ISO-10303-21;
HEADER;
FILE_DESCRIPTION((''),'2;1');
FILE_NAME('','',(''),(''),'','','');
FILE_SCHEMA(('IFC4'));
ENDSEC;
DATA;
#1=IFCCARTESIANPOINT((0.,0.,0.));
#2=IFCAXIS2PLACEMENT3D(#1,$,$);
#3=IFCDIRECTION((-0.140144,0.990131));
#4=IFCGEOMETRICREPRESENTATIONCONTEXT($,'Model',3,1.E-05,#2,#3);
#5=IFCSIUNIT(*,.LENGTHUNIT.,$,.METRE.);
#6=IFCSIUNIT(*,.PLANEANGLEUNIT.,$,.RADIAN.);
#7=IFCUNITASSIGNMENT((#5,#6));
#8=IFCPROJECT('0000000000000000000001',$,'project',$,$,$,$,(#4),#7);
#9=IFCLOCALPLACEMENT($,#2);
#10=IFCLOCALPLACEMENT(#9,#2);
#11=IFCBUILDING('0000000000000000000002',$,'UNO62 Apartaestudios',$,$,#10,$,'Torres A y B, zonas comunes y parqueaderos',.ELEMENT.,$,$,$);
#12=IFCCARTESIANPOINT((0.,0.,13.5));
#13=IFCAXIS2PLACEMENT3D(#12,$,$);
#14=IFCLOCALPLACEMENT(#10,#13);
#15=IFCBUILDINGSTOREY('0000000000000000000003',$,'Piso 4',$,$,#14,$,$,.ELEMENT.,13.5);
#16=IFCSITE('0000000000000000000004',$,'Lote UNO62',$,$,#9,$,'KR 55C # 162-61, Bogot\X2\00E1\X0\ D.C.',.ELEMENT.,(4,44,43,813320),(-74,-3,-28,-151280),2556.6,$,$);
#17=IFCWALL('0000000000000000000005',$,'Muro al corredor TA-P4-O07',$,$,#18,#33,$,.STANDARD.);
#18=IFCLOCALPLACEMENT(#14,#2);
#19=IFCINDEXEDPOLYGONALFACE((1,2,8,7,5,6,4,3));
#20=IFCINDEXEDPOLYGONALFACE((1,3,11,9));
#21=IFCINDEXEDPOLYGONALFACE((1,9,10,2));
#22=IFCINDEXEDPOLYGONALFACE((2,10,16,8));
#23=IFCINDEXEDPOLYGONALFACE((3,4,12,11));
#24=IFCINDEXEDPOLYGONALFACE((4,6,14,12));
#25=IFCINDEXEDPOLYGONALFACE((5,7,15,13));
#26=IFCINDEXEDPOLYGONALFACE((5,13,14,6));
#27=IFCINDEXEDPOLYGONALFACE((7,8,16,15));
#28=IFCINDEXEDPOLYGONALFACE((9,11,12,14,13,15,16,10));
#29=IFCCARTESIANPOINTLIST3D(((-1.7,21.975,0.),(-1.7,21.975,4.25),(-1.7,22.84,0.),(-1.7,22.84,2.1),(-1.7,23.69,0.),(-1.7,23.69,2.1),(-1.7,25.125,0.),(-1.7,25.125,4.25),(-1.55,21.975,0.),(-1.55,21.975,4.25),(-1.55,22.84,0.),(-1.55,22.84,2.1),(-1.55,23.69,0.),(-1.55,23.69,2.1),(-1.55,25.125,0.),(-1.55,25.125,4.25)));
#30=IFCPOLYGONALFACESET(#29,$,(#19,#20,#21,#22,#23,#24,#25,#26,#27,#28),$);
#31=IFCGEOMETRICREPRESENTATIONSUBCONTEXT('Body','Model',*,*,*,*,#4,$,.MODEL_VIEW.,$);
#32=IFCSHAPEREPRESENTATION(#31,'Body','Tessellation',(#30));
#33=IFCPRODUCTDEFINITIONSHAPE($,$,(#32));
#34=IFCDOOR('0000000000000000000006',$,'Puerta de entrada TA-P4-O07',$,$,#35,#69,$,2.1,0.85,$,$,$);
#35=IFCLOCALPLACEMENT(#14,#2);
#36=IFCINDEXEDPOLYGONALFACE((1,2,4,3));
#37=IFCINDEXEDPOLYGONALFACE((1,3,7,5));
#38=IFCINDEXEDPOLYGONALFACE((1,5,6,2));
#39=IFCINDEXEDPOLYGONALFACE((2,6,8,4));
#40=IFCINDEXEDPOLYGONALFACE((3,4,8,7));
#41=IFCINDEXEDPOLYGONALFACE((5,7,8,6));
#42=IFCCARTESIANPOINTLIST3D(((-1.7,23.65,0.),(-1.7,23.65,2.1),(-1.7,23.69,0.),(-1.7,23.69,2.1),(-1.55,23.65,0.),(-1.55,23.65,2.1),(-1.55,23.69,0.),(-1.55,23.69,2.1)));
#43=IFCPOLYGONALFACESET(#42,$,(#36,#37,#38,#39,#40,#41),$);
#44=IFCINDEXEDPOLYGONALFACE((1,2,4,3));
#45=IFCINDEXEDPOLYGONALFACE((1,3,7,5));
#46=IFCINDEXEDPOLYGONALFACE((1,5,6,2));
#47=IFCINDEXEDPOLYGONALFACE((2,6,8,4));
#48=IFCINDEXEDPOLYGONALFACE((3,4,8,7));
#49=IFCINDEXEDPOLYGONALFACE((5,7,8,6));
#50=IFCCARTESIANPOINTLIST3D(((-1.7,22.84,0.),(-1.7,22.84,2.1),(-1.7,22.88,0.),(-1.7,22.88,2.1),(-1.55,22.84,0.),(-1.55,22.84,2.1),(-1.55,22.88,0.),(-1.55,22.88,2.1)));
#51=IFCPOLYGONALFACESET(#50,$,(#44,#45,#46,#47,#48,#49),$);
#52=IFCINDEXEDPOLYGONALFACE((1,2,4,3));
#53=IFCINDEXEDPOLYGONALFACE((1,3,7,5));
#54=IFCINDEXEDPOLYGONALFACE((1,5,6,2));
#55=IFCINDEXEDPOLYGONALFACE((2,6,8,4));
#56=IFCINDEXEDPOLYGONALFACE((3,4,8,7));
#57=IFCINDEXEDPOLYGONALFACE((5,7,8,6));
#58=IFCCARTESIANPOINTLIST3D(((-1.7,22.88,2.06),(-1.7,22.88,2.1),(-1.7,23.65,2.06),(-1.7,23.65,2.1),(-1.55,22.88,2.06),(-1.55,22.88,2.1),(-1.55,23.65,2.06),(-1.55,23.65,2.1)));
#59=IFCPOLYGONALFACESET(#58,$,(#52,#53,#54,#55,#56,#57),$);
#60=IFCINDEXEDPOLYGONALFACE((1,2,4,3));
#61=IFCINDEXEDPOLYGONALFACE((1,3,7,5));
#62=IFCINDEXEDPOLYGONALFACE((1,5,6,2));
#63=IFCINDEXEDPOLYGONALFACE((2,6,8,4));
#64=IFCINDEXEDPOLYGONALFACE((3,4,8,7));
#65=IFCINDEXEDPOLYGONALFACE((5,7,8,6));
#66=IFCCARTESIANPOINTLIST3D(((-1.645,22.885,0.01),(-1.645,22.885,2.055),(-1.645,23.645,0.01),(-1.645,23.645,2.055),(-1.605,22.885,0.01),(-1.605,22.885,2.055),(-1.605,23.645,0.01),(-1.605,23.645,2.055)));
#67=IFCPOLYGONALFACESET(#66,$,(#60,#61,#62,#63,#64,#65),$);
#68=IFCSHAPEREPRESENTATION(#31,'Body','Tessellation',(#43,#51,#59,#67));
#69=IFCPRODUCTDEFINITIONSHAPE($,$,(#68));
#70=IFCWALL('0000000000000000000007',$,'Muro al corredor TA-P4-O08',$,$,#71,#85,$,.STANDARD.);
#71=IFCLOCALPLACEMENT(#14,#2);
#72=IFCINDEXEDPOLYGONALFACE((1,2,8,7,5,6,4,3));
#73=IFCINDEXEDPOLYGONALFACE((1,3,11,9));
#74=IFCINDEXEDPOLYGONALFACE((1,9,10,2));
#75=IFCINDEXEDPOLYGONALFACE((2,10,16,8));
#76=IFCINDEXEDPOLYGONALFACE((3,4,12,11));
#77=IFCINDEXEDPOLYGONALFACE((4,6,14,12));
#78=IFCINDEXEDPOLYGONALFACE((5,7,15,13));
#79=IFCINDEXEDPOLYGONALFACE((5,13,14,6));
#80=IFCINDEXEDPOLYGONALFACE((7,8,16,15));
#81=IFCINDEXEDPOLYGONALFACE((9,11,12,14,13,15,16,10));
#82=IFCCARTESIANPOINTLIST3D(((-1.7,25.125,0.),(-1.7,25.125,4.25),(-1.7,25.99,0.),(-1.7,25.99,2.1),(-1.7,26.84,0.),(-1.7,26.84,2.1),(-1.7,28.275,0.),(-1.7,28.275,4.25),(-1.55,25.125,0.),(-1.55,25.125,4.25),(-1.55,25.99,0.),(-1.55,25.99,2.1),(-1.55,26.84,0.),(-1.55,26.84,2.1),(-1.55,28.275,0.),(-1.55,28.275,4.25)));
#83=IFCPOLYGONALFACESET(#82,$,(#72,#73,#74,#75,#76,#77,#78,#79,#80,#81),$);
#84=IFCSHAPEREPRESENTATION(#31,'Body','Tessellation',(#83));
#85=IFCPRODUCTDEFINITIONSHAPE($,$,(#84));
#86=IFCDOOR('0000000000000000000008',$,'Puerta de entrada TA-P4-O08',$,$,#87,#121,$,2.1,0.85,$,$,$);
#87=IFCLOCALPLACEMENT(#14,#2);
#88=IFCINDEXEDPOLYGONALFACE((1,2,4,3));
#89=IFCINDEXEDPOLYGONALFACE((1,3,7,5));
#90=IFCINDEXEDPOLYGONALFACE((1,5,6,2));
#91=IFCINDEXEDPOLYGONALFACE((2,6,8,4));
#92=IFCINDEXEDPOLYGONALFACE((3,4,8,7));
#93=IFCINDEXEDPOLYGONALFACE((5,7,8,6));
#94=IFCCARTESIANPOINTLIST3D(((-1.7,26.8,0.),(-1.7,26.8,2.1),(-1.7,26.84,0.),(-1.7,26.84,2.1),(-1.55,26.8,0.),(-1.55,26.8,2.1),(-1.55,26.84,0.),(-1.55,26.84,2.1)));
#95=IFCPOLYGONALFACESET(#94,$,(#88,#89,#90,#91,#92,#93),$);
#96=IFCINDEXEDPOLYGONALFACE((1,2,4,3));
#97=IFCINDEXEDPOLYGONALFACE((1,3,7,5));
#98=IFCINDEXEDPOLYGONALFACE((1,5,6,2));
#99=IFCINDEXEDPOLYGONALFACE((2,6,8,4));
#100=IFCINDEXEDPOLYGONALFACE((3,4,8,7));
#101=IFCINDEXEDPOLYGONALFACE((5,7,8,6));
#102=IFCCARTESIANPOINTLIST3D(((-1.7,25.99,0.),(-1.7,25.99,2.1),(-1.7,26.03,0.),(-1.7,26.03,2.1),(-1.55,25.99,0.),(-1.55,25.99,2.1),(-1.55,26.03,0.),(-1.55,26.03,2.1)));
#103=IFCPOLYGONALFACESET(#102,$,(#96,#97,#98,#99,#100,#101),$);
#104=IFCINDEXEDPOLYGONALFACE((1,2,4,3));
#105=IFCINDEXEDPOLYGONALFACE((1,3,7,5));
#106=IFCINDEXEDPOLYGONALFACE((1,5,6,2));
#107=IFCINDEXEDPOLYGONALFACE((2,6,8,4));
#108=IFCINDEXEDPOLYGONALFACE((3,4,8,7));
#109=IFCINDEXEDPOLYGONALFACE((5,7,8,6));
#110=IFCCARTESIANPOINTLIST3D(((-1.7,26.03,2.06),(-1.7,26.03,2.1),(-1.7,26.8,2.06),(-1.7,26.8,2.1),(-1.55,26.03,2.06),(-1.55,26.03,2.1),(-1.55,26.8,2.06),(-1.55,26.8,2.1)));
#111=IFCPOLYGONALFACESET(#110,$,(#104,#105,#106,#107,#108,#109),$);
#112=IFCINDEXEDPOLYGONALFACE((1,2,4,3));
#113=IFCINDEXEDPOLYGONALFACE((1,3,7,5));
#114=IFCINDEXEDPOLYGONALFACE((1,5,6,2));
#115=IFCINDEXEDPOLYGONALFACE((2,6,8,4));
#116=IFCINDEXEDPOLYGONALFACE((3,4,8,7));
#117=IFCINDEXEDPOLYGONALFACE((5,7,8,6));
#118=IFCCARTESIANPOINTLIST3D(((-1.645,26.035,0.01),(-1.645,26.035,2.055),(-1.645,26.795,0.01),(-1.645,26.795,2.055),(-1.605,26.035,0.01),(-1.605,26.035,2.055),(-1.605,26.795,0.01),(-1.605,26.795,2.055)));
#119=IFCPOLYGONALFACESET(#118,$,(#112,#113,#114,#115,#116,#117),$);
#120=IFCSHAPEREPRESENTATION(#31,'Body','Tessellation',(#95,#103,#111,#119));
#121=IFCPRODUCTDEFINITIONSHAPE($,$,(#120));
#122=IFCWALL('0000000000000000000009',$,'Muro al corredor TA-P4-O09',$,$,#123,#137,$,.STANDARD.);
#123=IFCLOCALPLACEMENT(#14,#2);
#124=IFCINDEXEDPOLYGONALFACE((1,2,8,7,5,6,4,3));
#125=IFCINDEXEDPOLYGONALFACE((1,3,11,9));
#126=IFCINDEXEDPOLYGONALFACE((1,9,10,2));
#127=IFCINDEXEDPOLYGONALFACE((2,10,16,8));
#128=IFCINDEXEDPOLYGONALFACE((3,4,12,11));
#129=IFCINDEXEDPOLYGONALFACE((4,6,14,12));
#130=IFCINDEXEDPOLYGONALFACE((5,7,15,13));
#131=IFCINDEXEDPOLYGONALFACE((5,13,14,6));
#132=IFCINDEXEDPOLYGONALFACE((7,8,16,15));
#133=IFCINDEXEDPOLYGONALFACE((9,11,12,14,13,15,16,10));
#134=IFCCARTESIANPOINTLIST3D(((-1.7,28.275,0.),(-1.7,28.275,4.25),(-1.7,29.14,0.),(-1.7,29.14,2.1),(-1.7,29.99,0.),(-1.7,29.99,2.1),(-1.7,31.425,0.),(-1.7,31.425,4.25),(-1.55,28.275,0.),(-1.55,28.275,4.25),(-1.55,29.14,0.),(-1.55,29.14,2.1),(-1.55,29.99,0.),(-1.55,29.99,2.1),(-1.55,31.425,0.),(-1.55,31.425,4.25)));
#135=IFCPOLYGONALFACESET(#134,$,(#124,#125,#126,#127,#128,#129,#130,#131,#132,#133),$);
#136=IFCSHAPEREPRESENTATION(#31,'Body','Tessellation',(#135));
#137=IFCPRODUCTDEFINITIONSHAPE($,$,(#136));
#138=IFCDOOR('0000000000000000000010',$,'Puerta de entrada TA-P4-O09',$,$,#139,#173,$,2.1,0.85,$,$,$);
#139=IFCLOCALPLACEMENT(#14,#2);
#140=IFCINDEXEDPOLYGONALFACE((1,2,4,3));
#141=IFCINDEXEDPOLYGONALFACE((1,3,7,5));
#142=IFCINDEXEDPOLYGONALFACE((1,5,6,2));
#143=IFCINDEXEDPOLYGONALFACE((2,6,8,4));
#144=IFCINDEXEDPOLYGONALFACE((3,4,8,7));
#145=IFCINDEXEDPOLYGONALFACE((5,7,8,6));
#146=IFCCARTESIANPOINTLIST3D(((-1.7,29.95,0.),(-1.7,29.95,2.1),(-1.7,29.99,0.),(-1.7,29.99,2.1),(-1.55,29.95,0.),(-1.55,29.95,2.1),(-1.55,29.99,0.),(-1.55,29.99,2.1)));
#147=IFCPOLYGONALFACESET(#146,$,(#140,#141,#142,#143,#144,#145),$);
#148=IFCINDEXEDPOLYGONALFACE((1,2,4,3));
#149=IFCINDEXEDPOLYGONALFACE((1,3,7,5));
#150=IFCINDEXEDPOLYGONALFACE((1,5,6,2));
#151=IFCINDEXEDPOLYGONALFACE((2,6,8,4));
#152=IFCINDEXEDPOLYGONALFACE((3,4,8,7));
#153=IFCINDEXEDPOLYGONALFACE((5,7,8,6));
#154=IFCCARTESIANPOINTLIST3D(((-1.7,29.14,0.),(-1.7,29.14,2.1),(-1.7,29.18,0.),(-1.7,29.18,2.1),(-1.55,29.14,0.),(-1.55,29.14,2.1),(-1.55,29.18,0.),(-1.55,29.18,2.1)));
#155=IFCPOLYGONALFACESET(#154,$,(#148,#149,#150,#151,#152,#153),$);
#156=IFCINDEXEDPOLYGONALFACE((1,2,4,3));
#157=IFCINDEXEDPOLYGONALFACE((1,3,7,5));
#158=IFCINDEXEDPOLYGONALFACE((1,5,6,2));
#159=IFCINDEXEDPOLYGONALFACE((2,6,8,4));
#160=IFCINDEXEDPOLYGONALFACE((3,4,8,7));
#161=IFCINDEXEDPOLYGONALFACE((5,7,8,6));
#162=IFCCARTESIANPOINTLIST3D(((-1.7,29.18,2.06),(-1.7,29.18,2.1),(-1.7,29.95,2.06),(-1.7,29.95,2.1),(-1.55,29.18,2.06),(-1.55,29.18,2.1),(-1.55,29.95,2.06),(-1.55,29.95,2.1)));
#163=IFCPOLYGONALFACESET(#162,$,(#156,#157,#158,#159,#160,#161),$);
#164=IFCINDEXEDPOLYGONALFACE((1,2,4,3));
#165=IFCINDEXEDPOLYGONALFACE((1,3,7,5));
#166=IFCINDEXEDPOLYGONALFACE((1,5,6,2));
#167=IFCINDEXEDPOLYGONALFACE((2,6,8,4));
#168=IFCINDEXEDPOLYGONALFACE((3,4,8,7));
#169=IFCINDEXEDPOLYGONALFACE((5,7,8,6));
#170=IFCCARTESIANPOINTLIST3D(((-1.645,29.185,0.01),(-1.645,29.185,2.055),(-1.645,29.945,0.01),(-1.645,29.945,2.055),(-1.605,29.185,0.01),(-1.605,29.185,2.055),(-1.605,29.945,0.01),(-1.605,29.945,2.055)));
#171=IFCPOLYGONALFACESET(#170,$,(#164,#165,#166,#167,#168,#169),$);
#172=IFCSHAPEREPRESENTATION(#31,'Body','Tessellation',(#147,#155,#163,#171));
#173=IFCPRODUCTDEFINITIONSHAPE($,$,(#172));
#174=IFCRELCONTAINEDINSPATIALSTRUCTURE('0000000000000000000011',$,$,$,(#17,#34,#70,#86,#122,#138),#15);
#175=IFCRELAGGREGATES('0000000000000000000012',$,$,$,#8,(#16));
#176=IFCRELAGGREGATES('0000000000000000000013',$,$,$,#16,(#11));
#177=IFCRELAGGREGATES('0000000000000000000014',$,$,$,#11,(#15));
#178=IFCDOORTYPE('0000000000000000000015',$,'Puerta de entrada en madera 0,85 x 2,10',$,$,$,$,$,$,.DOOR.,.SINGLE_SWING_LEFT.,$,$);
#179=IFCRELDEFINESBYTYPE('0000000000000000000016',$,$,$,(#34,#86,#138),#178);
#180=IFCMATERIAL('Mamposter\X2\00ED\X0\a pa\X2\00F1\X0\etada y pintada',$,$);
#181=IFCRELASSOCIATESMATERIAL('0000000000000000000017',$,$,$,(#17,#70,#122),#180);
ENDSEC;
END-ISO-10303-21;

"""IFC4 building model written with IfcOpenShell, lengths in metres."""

from ifc_helpers import new_model, si_unit, direction, frame, frame_2d, origin, place, context, subcontext, project, spatial, rectangle, extrude, source, transform, mapped, material, type_object, type_shapes, element, fill, save


model = new_model("IFC4")

# Units and contexts
model_context = context("Model", 3, precision=1e-05, world=origin(), true_north=direction((-0.140144, 0.990131)))
body_context = subcontext(model_context, "Body", "Model", "MODEL_VIEW")
ifc_project = project(units=[si_unit("LENGTHUNIT", "METRE"), si_unit("PLANEANGLEUNIT", "RADIAN")], contexts=[model_context])

# Site, building, storey
site_placement = place(None, origin())
site = spatial("IfcSite", under=ifc_project, at=site_placement, Name="Lote UNO62", LongName="KR 55C # 162-61, Bogotá D.C.", CompositionType="ELEMENT", RefLatitude=(4, 44, 43, 813320), RefLongitude=(-74, -3, -28, -151280), RefElevation=2556.6)
building_placement = place(site_placement, origin())
building = spatial("IfcBuilding", under=site, at=building_placement, Name="UNO62 Apartaestudios", LongName="Torres A y B, zonas comunes y parqueaderos", CompositionType="ELEMENT")
storey_placement = place(building_placement, frame((0.0, 0.0, 13.5)))
storey = spatial("IfcBuildingStorey", under=building, at=storey_placement, Name="Piso 4", CompositionType="ELEMENT", Elevation=13.5)

# Walls, openings, doors
ifc_material = material(Name="Mampostería pañetada y pintada")
door_type = type_object("IfcDoorType", Name="Puerta de entrada en madera 0,85 x 2,10", OperationType="SINGLE_SWING_LEFT", PredefinedType="DOOR")
shared_shape = source(origin(), body_context, "Body", "SweptSolid", [
    extrude(rectangle(XDim=0.15, YDim=0.04, at=frame_2d((-0.075, 1.38))), origin(), (0.0, 0.0, 1.0), 2.1),
    extrude(rectangle(XDim=0.15, YDim=0.04, at=frame_2d((-0.075, 2.19))), origin(), (0.0, 0.0, 1.0), 2.1),
    extrude(rectangle(XDim=0.15, YDim=0.77, at=frame_2d((-0.075, 1.785))), frame((0.0, 0.0, 2.06)), (0.0, 0.0, 1.0), 0.04),
    extrude(rectangle(XDim=0.04, YDim=0.76, at=frame_2d((-0.075, 1.785))), frame((0.0, 0.0, 0.01)), (0.0, 0.0, 1.0), 2.045),
])
type_shapes(door_type, [shared_shape])
wall_1_placement = place(storey_placement, origin())
wall_1 = element("IfcWall", 1, at=wall_1_placement, inside=storey, material=ifc_material, Name="Muro al corredor TA-P4-O07", PredefinedType="STANDARD", context=body_context, shape_type="SweptSolid", body=[
    extrude(rectangle(XDim=0.15, YDim=3.15, at=frame_2d((-1.625, 23.55))), origin(), (0.0, 0.0, 1.0), 4.25),
])
opening_1_placement = place(wall_1_placement, origin())
opening_1 = element("IfcOpeningElement", 2, at=opening_1_placement, cuts=wall_1, PredefinedType="OPENING", context=body_context, shape_type="SweptSolid", body=[
    extrude(rectangle(XDim=0.25, YDim=0.85, at=frame_2d((-1.625, 23.265))), origin(), (0.0, 0.0, 1.0), 2.1),
])
placement_1 = place(storey_placement, frame((-1.7, 25.05, 0.0), z_axis=(0.0, 0.0, 1.0), x_axis=(-1.0, 0.0, 0.0)))
door_1_placement = place(placement_1, origin())
door_1 = element("IfcDoor", 3, at=door_1_placement, inside=storey, type_object=door_type, Name="Puerta de entrada TA-P4-O07", OverallHeight=2.1, OverallWidth=0.85, context=body_context, shape_type="MappedRepresentation", body=[
    mapped(shared_shape, transform((0.0, 0.0, 0.0))),
])
fill(opening_1, door_1)
wall_2_placement = place(storey_placement, origin())
wall_2 = element("IfcWall", 4, at=wall_2_placement, inside=storey, material=ifc_material, Name="Muro al corredor TA-P4-O08", PredefinedType="STANDARD", context=body_context, shape_type="SweptSolid", body=[
    extrude(rectangle(XDim=0.15, YDim=3.15, at=frame_2d((-1.625, 26.7))), origin(), (0.0, 0.0, 1.0), 4.25),
])
opening_2_placement = place(wall_2_placement, origin())
opening_2 = element("IfcOpeningElement", 5, at=opening_2_placement, cuts=wall_2, PredefinedType="OPENING", context=body_context, shape_type="SweptSolid", body=[
    extrude(rectangle(XDim=0.25, YDim=0.85, at=frame_2d((-1.625, 26.415))), origin(), (0.0, 0.0, 1.0), 2.1),
])
placement_2 = place(storey_placement, frame((-1.7, 28.2, 0.0), z_axis=(0.0, 0.0, 1.0), x_axis=(-1.0, 0.0, 0.0)))
door_2_placement = place(placement_2, origin())
door_2 = element("IfcDoor", 6, at=door_2_placement, inside=storey, type_object=door_type, Name="Puerta de entrada TA-P4-O08", OverallHeight=2.1, OverallWidth=0.85, context=body_context, shape_type="MappedRepresentation", body=[
    mapped(shared_shape, transform((0.0, 0.0, 0.0))),
])
fill(opening_2, door_2)
wall_3_placement = place(storey_placement, origin())
wall_3 = element("IfcWall", 7, at=wall_3_placement, inside=storey, material=ifc_material, Name="Muro al corredor TA-P4-O09", PredefinedType="STANDARD", context=body_context, shape_type="SweptSolid", body=[
    extrude(rectangle(XDim=0.15, YDim=3.15, at=frame_2d((-1.625, 29.85))), origin(), (0.0, 0.0, 1.0), 4.25),
])
opening_3_placement = place(wall_3_placement, origin())
opening_3 = element("IfcOpeningElement", 8, at=opening_3_placement, cuts=wall_3, PredefinedType="OPENING", context=body_context, shape_type="SweptSolid", body=[
    extrude(rectangle(XDim=0.25, YDim=0.85, at=frame_2d((-1.625, 29.565))), origin(), (0.0, 0.0, 1.0), 2.1),
])
placement_3 = place(storey_placement, frame((-1.7, 31.35, 0.0), z_axis=(0.0, 0.0, 1.0), x_axis=(-1.0, 0.0, 0.0)))
door_3_placement = place(placement_3, origin())
door_3 = element("IfcDoor", 9, at=door_3_placement, inside=storey, type_object=door_type, Name="Puerta de entrada TA-P4-O09", OverallHeight=2.1, OverallWidth=0.85, context=body_context, shape_type="MappedRepresentation", body=[
    mapped(shared_shape, transform((0.0, 0.0, 0.0))),
])
fill(opening_3, door_3)

save(model, "model.ifc")
